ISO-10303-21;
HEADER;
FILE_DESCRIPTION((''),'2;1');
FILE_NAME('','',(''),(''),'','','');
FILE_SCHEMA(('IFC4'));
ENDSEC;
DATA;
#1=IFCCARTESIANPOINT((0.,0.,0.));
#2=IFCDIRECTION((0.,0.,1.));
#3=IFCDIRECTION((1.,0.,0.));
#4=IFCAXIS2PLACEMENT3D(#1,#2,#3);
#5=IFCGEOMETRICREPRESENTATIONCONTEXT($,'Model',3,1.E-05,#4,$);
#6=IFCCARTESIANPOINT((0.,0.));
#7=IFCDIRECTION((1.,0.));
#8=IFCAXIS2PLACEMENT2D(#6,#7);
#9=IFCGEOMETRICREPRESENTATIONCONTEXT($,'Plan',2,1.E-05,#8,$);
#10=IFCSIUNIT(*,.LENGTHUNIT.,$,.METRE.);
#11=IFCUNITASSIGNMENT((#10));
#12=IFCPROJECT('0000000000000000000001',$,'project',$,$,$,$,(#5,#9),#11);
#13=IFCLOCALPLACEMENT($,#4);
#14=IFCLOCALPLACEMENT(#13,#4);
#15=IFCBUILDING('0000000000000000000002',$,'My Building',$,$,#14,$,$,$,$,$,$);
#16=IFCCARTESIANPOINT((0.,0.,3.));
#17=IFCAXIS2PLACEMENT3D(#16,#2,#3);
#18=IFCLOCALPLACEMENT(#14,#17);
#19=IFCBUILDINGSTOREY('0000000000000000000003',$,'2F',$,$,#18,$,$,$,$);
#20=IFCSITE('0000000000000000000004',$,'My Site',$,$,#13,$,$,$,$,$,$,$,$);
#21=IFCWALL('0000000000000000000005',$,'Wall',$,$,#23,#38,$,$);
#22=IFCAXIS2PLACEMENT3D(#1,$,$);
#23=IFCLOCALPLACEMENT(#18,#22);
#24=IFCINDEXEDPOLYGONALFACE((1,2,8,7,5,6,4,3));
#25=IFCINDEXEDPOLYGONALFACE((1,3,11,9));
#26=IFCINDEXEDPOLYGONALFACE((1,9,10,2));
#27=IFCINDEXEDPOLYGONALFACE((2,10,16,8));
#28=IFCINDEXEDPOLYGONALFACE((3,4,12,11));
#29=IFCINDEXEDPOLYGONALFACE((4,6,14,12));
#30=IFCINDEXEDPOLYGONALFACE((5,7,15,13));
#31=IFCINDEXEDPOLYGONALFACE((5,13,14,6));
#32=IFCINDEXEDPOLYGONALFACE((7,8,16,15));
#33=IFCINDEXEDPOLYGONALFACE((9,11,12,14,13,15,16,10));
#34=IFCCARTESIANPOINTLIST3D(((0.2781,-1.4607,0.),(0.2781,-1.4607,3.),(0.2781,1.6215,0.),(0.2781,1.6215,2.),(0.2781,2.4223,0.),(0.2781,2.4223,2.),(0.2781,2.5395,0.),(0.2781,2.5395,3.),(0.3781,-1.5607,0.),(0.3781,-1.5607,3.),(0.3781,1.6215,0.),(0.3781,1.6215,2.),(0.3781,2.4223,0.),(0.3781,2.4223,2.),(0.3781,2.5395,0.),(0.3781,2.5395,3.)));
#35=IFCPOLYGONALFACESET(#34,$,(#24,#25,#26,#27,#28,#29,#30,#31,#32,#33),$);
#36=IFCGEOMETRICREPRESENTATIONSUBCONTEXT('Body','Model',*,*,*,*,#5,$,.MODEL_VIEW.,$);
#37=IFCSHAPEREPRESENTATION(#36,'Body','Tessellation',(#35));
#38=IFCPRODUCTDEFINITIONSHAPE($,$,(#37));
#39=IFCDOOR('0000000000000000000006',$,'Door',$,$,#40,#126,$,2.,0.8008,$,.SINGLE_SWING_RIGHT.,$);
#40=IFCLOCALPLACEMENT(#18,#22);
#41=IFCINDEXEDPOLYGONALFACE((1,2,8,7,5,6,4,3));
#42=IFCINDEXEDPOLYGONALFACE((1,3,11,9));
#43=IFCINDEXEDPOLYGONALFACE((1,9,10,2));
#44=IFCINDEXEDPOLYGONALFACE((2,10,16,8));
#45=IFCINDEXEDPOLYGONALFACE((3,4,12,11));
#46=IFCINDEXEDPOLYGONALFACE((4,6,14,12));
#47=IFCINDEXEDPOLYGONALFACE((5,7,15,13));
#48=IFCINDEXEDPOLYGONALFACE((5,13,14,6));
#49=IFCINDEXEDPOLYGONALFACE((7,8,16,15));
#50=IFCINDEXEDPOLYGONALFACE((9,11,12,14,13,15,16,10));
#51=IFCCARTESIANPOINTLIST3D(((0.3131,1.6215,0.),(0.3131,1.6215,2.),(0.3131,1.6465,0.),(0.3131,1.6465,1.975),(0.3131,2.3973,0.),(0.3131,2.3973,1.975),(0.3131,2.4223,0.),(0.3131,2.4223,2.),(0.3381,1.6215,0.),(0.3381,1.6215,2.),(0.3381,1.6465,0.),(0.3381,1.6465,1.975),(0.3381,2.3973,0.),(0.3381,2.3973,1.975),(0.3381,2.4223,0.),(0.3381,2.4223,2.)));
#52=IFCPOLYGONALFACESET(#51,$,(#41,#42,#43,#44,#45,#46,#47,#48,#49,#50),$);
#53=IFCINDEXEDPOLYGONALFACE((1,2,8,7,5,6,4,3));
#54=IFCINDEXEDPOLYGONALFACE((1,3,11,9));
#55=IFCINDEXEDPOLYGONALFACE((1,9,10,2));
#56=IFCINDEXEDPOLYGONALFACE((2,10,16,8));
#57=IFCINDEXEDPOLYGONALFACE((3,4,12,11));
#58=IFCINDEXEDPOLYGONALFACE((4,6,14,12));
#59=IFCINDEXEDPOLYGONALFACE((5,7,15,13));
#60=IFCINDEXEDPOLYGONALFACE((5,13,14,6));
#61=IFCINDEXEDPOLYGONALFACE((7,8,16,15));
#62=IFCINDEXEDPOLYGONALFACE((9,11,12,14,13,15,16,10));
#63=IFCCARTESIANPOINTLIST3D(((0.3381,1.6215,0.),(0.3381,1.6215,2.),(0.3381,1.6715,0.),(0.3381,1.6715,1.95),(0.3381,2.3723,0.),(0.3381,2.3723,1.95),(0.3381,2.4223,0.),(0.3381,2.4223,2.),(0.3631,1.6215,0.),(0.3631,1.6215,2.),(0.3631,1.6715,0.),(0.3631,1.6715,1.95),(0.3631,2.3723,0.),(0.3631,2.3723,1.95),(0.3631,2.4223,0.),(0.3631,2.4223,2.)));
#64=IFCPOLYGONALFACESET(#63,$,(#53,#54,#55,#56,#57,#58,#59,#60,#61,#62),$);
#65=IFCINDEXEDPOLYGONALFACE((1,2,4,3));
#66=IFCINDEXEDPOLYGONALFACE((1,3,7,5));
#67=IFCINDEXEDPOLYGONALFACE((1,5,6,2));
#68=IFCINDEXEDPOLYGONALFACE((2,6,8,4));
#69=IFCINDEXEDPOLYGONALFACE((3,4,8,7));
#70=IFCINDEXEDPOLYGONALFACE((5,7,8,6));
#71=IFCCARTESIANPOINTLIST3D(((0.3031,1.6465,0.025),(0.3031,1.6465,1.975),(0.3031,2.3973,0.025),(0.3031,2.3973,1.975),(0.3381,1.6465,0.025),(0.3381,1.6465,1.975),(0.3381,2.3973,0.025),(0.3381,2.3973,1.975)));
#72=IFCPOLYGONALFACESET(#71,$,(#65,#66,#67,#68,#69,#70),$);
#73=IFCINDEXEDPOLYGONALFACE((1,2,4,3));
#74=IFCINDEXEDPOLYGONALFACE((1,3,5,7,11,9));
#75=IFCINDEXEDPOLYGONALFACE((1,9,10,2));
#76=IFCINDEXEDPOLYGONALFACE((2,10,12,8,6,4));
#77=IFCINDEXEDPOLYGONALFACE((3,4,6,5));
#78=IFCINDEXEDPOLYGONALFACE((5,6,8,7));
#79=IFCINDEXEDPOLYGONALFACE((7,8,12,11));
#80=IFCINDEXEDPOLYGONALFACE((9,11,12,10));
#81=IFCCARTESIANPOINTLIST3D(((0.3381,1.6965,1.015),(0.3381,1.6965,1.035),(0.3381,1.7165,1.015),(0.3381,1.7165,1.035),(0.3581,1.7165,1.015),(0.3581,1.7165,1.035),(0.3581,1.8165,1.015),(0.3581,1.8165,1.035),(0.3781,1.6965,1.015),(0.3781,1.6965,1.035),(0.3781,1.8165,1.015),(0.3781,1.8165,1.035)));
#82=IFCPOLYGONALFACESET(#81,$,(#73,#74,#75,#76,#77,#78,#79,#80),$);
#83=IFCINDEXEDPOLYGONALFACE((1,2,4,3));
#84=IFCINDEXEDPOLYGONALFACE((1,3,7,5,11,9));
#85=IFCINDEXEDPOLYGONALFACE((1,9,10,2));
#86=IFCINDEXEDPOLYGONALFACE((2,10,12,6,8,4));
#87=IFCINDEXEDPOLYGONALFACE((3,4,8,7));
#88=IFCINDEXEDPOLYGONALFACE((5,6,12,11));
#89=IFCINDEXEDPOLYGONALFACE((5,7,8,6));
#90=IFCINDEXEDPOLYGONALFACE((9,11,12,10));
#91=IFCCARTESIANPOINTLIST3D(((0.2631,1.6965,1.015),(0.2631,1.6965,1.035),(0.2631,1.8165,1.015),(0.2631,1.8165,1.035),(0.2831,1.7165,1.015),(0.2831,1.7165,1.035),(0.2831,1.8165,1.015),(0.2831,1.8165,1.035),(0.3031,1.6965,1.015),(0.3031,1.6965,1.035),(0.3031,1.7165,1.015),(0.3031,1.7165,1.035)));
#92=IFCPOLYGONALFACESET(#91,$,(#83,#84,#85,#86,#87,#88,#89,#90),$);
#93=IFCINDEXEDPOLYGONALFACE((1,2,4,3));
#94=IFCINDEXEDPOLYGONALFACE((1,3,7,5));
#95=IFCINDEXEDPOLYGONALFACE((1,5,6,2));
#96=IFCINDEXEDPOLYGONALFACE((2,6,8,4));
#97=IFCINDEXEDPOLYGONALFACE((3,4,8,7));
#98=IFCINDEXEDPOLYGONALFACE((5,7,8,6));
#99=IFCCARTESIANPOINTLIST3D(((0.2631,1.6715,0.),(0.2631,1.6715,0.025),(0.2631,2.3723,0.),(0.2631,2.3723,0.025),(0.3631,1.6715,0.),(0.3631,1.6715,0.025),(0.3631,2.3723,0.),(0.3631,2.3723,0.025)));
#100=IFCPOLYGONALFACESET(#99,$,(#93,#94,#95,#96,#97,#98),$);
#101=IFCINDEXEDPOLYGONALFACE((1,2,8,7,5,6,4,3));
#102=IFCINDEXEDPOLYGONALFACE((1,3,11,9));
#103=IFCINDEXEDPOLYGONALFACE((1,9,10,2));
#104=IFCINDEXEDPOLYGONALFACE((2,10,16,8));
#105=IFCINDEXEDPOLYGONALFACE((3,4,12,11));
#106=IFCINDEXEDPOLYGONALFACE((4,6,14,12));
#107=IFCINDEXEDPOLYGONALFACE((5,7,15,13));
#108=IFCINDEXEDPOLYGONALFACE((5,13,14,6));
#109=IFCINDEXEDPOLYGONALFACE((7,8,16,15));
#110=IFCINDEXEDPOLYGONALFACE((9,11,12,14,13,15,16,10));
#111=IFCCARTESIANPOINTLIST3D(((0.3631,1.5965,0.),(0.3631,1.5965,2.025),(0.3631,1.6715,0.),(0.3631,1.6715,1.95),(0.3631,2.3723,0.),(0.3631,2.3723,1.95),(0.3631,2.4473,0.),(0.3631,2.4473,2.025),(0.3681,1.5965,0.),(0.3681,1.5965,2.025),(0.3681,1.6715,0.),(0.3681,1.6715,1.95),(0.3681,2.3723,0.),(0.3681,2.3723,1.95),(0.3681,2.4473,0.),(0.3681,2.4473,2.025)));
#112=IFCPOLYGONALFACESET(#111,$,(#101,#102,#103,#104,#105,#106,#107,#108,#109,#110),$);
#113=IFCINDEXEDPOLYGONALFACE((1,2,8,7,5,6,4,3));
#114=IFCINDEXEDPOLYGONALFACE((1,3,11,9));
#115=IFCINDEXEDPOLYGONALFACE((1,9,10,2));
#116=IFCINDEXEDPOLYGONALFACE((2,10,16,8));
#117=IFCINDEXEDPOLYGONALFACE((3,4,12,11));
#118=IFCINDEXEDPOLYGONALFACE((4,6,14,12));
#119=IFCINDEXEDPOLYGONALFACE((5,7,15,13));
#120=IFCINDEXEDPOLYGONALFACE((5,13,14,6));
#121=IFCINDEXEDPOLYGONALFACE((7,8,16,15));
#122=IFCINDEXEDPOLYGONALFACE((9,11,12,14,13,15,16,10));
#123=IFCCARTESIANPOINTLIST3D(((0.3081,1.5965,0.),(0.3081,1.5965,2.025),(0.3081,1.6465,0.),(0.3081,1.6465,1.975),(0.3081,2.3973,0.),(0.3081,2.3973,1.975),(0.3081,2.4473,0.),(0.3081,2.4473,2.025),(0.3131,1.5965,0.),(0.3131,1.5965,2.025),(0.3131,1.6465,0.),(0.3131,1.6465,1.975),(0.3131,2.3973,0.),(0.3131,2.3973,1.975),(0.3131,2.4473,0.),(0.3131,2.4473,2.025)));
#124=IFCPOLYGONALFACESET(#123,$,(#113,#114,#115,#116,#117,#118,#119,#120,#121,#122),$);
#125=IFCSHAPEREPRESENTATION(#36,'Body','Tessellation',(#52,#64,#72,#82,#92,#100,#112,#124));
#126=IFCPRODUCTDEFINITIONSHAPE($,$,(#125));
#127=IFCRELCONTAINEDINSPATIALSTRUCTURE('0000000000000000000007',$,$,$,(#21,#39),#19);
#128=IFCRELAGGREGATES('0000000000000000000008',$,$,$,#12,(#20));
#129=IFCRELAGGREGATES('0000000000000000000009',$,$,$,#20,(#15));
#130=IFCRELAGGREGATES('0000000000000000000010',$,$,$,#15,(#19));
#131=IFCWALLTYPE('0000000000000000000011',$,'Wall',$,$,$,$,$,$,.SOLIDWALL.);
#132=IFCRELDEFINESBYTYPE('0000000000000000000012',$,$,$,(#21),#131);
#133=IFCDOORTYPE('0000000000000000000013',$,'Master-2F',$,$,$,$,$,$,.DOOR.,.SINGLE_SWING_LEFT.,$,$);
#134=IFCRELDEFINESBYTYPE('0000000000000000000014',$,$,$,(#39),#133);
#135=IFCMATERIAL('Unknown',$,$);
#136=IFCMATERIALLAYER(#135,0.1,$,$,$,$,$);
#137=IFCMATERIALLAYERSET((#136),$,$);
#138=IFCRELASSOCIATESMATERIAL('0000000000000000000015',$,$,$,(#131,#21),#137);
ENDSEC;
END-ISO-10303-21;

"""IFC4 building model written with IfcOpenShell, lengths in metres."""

from ifc_helpers import new_model, entity, si_unit, frame, origin_with_axes, origin_2d_with_axis, place, context, subcontext, project, spatial, line, indexed_curve, outline, extrude, shape, source, transform, mapped, material, layer, layer_set, layer_usage, type_object, type_shapes, element, fill, save


model = new_model("IFC4")

# Units and contexts
model_context = context("Model", 3, precision=1e-05, world=origin_with_axes())
plan_context = context("Plan", 2, precision=1e-05, world=origin_2d_with_axis())
body_context_1 = subcontext(model_context, "Body", "Model", "MODEL_VIEW")
body_context_2 = subcontext(plan_context, "Body", "Plan", "PLAN_VIEW")
ifc_project = project(units=[si_unit("LENGTHUNIT", "METRE")], contexts=[model_context, plan_context])

# Site, building, storey
site_placement = place(None, origin_with_axes())
site = spatial("IfcSite", under=ifc_project, at=site_placement, Name="My Site")
building_placement = place(site_placement, origin_with_axes())
building = spatial("IfcBuilding", under=site, at=building_placement, Name="My Building")
storey_placement = place(building_placement, frame((0.0, 0.0, 3.0), z_axis=(0.0, 0.0, 1.0), x_axis=(1.0, 0.0, 0.0)))
storey = spatial("IfcBuildingStorey", under=building, at=storey_placement, Name="2F")

# Shared definitions
ifc_material = material(Name="Unknown")

# Shared definitions
ifc_layer_1 = layer(ifc_material, 0.1)
ifc_layer_set_1 = layer_set([ifc_layer_1])
wall_type = type_object("IfcWallType", Name="Wall", PredefinedType="SOLIDWALL", material=ifc_layer_set_1)

# Wall, opening, door
ifc_layer_usage_1 = layer_usage(ifc_layer_set_1, "AXIS2", "POSITIVE", 0.0)
wall_1_placement = place(storey_placement, frame((0.3781, -1.5607, 0.0), z_axis=(0.0, 0.0, 1.0), x_axis=(0.0, 1.0, 0.0)))
wall_1 = element("IfcWall", 1, at=wall_1_placement, inside=storey, type_object=wall_type, material=ifc_layer_usage_1, Name="Wall", context=body_context_1, shape_type="SweptSolid", body=[
    extrude(outline(indexed_curve([(0.0, 0.0), (0.1, 0.1), (4.1002, 0.1), (4.1002, 0.0)], segments=[line(1, 2, 3, 4, 1)])), origin_with_axes(), (0.0, 0.0, 1.0), 3.0),
])
shared_shape_1 = source(origin_with_axes(), body_context_1, "Body", "SweptSolid", [
    extrude(outline(indexed_curve([(0.0, 0.0), (0.8008, 0.0), (0.8008, 2.0), (0.0, 2.0)], segments=[line(1, 2, 3, 4, 1)])), frame((0.0, -0.6, 0.0), z_axis=(0.0, -1.0, 0.0), x_axis=(1.0, 0.0, 0.0)), (0.0, 0.0, -1.0), 1.2),
])
opening_1_placement = place(wall_1_placement, frame((3.1821, 0.015, 0.0), z_axis=(0.0, 0.0, 1.0), x_axis=(1.0, 0.0, 0.0)))
opening_1 = element("IfcOpeningElement", 2, at=opening_1_placement, cuts=wall_1, PredefinedType="OPENING", context=body_context_1, shape_type="MappedRepresentation", body=[
    mapped(shared_shape_1, transform((0.0, 0.0, 0.0), x_axis=(1.0, 0.0, 0.0), y_axis=(0.0, 1.0, 0.0), z_axis=(0.0, 0.0, 1.0), scale=1.0)),
])
door_type_1 = type_object("IfcDoorType", Name="Master-2F", OperationType="SINGLE_SWING_LEFT", PredefinedType="DOOR")
shared_shape_2 = source(origin_with_axes(), body_context_1, "Body", "SweptSolid", [
    extrude(outline(indexed_curve([(0.0, 0.0), (0.0, 2.0), (0.8008, 2.0), (0.8008, 0.0), (0.7758, 0.0), (0.7758, 1.975), (0.025, 1.975), (0.025, 0.0)], segments=[line(1, 2, 3, 4, 5, 6, 7, 8, 1)])), frame((0.0, 0.025, 0.0), z_axis=(0.0, -1.0, 0.0), x_axis=(1.0, 0.0, 0.0)), (0.0, 0.0, -1.0), 0.025),
    extrude(outline(indexed_curve([(0.0, 0.0), (0.0, 2.0), (0.8008, 2.0), (0.8008, 0.0), (0.7508, 0.0), (0.7508, 1.95), (0.05, 1.95), (0.05, 0.0)], segments=[line(1, 2, 3, 4, 5, 6, 7, 8, 1)])), frame((0.0, 0.0, 0.0), z_axis=(0.0, -1.0, 0.0), x_axis=(1.0, 0.0, 0.0)), (0.0, 0.0, -1.0), 0.025),
    extrude(outline(indexed_curve([(0.0, 0.0), (0.7508, 0.0), (0.7508, 0.035), (0.0, 0.035)], segments=[line(1, 2, 3, 4, 1)])), frame((0.025, 0.025, 0.025), z_axis=(0.0, 0.0, 1.0), x_axis=(1.0, 0.0, 0.0)), (0.0, 0.0, 1.0), 1.95),
    extrude(outline(indexed_curve([(0.0, 0.0), (0.0, -0.04), (0.12, -0.04), (0.12, -0.02), (0.02, -0.02), (0.02, 0.0)], segments=[line(1, 2, 3, 4, 5, 6, 1)])), frame((0.075, 0.025, 1.015), z_axis=(0.0, 0.0, 1.0), x_axis=(1.0, 0.0, 0.0)), (0.0, 0.0, 1.0), 0.02),
    extrude(outline(indexed_curve([(0.0, 0.0), (0.0, 0.04), (0.12, 0.04), (0.12, 0.02), (0.02, 0.02), (0.02, 0.0)], segments=[line(1, 2, 3, 4, 5, 6, 1)])), frame((0.075, 0.06, 1.015), z_axis=(0.0, 0.0, 1.0), x_axis=(1.0, 0.0, 0.0)), (0.0, 0.0, 1.0), 0.02),
    extrude(outline(indexed_curve([(0.0, 0.0), (0.7008, 0.0), (0.7008, 0.1), (0.0, 0.1)], segments=[line(1, 2, 3, 4, 1)])), frame((0.05, 0.0, 0.0), z_axis=(0.0, 0.0, 1.0), x_axis=(1.0, 0.0, 0.0)), (0.0, 0.0, 1.0), 0.025),
    extrude(outline(indexed_curve([(0.0, 0.0), (0.0, 2.025), (0.8508, 2.025), (0.8508, 0.0), (0.7758, 0.0), (0.7758, 1.95), (0.075, 1.95), (0.075, 0.0)], segments=[line(1, 2, 3, 4, 5, 6, 7, 8, 1)])), frame((-0.025, -0.005, 0.0), z_axis=(0.0, -1.0, 0.0), x_axis=(1.0, 0.0, 0.0)), (0.0, 0.0, -1.0), 0.005),
    extrude(outline(indexed_curve([(0.0, 0.0), (0.0, 2.025), (0.8508, 2.025), (0.8508, 0.0), (0.8008, 0.0), (0.8008, 1.975), (0.05, 1.975), (0.05, 0.0)], segments=[line(1, 2, 3, 4, 5, 6, 7, 8, 1)])), frame((-0.025, 0.05, 0.0), z_axis=(0.0, -1.0, 0.0), x_axis=(1.0, 0.0, 0.0)), (0.0, 0.0, -1.0), 0.005),
])
shared_shape_3 = source(origin_with_axes(), body_context_2, "Body", "Curve2D", [
    entity("IfcIndexedPolyCurve", entity("IfcCartesianPointList2D", [[0.0, 0.0], [0.0, 0.05], [0.025, 0.05], [0.025, 0.025], [0.05, 0.025], [0.05, 0.0]]), [entity("IfcLineIndex", [1, 2, 3, 4, 5, 6, 1])]),
    entity("IfcIndexedPolyCurve", entity("IfcCartesianPointList2D", [[0.8008, 0.0], [0.8008, 0.05], [0.7758, 0.05], [0.7758, 0.025], [0.7508, 0.025], [0.7508, 0.0]]), [entity("IfcLineIndex", [1, 2, 3, 4, 5, 6, 1])]),
    entity("IfcTrimmedCurve", entity("IfcEllipse", entity("IfcAxis2Placement2D", entity("IfcCartesianPoint", [0.7408, 0.05]), entity("IfcDirection", [1.0, 0.0])), 0.7158, 0.7508), [entity("IfcCartesianPoint", [0.7408, 0.8008])], [entity("IfcCartesianPoint", [0.025, 0.05])], True, "CARTESIAN"),
    entity("IfcIndexedPolyCurve", entity("IfcCartesianPointList2D", [[0.7758, 0.05], [0.7408, 0.05], [0.7408, 0.8008], [0.7758, 0.8008]]), [entity("IfcLineIndex", [1, 2, 3, 4, 1])]),
])
type_shapes(door_type_1, [shared_shape_2, shared_shape_3])
door_1_placement = place(opening_1_placement, frame((0.0, 0.0, 0.0), z_axis=(0.0, 0.0, 1.0), x_axis=(1.0, 0.0, 0.0)))
door_1 = element("IfcDoor", 3, at=door_1_placement, inside=storey, type_object=door_type_1, Name="Door", OperationType="SINGLE_SWING_RIGHT", OverallHeight=2.0, OverallWidth=0.8008, shapes=[
    shape(body_context_1, "Body", "MappedRepresentation", [mapped(shared_shape_2, transform((0.0, 0.0, 0.0), x_axis=(1.0, 0.0, 0.0), y_axis=(0.0, 1.0, 0.0), z_axis=(0.0, 0.0, 1.0), scale=1.0))]),
    shape(body_context_2, "Body", "MappedRepresentation", [mapped(shared_shape_3, transform((0.0, 0.0, 0.0), x_axis=(1.0, 0.0, 0.0), y_axis=(0.0, 1.0, 0.0), z_axis=(0.0, 0.0, 1.0), scale=1.0))]),
])
fill(opening_1, door_1)

save(model, "model.ifc")
